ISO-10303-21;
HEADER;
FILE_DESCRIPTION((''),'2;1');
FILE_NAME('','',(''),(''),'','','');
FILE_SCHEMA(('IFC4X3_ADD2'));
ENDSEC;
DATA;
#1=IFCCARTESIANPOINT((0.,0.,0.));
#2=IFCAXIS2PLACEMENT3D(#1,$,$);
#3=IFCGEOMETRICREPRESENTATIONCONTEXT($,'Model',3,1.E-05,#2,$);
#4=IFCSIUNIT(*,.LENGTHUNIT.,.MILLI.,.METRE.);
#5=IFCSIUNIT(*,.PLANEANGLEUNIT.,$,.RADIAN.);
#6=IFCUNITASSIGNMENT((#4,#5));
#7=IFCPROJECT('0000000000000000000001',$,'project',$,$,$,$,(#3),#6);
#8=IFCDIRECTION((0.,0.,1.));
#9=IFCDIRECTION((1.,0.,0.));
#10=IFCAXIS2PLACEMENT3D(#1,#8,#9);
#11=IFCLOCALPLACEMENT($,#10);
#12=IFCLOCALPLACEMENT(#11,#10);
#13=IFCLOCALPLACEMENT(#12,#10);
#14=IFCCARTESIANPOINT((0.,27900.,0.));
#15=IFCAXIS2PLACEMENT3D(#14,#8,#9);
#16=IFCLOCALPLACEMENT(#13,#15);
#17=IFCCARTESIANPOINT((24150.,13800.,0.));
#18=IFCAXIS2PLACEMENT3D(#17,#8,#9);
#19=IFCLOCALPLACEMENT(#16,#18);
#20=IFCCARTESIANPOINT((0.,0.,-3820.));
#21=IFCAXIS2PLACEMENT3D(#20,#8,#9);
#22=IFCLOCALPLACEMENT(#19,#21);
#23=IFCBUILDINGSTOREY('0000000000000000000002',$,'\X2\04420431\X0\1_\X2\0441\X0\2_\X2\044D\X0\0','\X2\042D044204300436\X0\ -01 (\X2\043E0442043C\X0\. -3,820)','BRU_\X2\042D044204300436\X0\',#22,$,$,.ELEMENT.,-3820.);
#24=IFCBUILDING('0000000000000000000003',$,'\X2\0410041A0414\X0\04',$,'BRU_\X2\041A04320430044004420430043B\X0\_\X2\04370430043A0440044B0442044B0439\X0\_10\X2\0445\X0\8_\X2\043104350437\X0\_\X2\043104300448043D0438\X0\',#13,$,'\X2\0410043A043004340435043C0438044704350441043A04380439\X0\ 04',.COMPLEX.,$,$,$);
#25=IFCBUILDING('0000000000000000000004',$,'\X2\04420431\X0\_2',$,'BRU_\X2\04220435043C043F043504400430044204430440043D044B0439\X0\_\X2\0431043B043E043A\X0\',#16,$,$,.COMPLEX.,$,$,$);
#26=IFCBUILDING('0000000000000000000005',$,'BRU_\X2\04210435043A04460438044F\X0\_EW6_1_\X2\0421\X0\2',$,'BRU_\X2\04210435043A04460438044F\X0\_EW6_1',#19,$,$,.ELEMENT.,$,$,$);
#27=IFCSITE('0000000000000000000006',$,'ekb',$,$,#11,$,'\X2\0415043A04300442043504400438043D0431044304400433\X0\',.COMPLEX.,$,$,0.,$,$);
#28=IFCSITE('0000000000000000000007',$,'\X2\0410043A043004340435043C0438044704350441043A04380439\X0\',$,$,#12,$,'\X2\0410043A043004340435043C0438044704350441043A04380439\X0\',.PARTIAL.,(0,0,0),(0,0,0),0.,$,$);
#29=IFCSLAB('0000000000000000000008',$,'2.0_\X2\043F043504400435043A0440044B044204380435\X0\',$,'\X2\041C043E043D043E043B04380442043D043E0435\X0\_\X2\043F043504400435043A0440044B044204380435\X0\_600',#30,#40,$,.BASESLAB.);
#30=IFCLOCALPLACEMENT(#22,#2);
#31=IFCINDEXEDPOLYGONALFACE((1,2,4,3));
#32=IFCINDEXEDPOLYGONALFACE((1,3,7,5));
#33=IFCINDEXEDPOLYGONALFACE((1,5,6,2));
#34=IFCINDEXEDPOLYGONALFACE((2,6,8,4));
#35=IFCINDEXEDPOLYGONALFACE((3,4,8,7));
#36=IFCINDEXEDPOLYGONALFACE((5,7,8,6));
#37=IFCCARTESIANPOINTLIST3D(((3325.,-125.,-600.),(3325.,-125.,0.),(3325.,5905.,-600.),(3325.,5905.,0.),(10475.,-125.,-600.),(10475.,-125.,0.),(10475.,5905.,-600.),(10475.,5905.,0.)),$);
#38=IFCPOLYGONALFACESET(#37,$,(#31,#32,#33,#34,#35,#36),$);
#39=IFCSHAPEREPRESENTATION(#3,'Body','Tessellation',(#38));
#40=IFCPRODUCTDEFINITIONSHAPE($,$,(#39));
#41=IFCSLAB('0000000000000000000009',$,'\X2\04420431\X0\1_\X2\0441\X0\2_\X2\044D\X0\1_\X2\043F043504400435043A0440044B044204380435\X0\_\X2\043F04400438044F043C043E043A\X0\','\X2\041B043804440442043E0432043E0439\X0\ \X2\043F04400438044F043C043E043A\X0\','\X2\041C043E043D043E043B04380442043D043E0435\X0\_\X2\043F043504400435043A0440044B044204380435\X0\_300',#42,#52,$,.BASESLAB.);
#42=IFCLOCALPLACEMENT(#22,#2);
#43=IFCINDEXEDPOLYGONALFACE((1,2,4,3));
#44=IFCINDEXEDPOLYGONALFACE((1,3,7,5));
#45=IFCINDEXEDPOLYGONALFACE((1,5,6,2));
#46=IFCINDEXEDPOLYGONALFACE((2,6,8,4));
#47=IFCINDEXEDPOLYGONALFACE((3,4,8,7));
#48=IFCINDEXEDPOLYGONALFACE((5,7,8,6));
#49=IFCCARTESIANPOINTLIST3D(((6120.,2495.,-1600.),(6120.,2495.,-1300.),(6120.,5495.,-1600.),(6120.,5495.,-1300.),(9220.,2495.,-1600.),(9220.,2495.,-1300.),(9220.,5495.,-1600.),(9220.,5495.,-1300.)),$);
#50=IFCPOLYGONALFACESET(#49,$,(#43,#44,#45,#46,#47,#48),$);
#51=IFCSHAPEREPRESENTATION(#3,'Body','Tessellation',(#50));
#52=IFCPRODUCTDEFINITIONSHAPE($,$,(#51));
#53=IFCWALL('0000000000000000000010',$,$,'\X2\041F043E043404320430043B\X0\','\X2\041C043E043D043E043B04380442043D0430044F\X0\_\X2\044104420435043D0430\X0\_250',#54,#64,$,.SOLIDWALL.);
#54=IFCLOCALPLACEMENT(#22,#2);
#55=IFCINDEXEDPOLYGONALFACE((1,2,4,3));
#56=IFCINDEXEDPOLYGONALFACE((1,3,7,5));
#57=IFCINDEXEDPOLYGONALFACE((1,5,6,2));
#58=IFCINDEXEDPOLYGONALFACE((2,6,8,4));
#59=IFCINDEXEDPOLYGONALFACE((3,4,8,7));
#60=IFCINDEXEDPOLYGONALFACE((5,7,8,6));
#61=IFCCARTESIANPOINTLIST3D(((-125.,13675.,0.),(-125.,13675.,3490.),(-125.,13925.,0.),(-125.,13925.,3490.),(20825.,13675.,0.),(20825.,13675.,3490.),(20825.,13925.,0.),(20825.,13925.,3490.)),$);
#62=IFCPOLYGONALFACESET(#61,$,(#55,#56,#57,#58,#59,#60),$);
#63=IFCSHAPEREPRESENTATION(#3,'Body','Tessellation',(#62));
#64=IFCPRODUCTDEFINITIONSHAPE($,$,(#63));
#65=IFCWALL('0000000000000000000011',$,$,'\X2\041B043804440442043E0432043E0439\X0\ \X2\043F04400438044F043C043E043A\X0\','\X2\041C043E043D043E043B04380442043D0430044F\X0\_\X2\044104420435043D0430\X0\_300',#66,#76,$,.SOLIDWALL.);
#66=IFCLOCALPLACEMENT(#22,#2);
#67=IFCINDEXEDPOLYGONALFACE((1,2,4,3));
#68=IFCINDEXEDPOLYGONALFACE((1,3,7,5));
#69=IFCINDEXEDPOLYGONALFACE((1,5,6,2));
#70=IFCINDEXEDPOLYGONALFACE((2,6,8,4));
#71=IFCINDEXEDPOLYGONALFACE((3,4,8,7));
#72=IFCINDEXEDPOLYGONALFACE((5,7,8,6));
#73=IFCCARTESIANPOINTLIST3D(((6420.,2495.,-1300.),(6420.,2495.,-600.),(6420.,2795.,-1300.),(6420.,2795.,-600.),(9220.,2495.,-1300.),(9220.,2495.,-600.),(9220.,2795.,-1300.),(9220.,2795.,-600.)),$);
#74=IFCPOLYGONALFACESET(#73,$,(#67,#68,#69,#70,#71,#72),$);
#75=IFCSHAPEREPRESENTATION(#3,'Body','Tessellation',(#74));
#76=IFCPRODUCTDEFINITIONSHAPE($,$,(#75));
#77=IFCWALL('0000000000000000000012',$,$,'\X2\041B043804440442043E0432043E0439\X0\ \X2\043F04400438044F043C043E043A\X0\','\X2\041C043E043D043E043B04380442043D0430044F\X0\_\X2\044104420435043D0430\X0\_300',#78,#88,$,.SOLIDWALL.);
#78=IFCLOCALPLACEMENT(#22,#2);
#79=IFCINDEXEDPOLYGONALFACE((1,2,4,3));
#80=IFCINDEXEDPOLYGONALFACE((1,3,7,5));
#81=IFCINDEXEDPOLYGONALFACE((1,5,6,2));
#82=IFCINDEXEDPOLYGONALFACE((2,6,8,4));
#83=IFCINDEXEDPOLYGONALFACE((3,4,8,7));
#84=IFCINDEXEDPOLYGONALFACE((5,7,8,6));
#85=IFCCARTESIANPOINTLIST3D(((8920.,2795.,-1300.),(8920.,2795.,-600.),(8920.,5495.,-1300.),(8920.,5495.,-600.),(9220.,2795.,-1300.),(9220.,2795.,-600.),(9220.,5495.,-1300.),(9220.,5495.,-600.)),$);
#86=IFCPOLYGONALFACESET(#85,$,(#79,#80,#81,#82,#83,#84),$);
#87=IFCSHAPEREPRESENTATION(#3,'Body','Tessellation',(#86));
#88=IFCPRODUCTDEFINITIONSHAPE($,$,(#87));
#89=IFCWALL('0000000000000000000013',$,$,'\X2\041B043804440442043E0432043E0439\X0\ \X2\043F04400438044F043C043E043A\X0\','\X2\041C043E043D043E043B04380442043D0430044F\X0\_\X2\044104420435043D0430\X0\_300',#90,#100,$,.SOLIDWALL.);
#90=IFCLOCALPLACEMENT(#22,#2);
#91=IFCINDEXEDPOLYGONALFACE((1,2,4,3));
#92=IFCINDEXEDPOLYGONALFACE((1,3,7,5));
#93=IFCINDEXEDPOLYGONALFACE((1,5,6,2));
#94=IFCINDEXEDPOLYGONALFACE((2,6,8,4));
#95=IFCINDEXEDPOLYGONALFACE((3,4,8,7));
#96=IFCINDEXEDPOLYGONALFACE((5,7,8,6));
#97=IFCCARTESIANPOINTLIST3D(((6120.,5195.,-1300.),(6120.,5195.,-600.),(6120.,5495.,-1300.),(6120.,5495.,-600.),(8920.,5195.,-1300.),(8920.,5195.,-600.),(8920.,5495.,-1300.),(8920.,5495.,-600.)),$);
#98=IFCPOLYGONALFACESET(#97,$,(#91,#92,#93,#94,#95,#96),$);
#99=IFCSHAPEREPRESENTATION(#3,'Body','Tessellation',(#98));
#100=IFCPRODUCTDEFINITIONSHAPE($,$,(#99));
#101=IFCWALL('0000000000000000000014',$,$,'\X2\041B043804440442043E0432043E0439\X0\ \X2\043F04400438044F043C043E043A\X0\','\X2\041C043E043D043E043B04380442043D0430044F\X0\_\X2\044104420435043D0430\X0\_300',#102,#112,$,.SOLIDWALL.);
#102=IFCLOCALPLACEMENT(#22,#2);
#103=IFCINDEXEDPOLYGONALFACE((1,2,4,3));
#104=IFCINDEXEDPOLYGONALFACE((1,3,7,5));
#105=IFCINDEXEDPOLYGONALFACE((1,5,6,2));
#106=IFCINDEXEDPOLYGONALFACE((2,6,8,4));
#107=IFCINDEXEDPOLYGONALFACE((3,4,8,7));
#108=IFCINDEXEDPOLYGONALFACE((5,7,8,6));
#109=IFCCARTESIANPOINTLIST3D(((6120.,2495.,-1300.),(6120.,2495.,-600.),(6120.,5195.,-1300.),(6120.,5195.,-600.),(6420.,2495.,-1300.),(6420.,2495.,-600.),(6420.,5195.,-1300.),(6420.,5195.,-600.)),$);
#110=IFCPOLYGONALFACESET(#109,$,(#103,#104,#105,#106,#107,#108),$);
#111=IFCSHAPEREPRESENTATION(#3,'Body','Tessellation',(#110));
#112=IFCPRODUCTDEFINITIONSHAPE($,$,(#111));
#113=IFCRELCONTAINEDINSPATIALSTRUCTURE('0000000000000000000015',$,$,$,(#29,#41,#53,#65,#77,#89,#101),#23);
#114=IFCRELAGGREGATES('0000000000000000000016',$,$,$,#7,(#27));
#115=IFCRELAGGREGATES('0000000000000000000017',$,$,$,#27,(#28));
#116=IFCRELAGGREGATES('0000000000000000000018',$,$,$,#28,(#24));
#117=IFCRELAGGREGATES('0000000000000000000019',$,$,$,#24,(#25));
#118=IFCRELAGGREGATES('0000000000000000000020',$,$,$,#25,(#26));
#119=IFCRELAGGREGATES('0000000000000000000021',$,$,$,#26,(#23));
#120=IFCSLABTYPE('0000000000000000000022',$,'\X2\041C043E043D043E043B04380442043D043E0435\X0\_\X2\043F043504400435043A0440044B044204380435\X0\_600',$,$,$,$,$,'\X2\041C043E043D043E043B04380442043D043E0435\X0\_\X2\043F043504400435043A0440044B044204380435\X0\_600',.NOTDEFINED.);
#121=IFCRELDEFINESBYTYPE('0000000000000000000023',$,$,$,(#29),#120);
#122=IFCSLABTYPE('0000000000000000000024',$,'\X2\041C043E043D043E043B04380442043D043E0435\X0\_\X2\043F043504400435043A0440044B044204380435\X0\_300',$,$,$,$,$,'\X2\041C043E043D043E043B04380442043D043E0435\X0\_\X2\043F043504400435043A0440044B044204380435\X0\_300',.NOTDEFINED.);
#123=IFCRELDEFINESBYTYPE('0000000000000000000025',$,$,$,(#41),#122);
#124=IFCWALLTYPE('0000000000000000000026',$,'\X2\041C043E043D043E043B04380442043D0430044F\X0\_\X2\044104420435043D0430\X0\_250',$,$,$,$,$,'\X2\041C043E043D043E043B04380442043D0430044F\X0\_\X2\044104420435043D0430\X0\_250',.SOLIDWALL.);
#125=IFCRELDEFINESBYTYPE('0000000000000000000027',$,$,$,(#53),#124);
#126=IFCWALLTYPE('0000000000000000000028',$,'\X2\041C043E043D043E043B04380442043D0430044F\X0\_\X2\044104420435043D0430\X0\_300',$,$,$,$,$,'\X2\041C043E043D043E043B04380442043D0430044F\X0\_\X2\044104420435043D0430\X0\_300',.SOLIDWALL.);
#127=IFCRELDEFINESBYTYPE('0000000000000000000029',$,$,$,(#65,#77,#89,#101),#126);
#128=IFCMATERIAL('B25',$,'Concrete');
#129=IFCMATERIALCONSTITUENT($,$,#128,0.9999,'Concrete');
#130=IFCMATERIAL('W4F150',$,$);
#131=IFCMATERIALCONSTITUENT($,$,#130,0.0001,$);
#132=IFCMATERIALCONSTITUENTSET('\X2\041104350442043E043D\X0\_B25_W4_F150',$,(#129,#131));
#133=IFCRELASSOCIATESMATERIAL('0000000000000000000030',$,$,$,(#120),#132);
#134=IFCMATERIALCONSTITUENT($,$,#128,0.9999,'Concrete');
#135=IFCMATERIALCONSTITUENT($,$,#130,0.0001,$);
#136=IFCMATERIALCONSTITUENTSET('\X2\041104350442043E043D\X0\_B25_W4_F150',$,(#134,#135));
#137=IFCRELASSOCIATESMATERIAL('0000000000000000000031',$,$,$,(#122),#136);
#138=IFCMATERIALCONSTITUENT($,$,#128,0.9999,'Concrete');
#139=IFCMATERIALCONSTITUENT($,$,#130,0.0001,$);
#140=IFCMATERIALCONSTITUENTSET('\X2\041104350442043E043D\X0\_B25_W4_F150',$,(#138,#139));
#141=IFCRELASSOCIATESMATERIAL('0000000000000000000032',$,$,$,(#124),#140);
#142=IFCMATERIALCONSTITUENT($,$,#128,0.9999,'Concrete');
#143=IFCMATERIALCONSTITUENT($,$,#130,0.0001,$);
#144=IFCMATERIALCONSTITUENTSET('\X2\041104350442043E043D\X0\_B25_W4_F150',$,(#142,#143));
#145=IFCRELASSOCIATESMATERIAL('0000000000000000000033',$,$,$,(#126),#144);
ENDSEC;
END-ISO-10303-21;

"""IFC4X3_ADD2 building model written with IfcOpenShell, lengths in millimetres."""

from ifc_helpers import new_model, si_unit, frame, origin, origin_with_axes, origin_2d_with_axis, place, context, project, spatial, polyline, rectangle, outline, extrude, material, constituent, constituent_set, type_object, element, save


model = new_model("IFC4X3_ADD2")

# Units and contexts
model_context = context("Model", 3, precision=1e-05, world=origin())
ifc_project = project(units=[si_unit("LENGTHUNIT", "METRE", prefix="MILLI"), si_unit("PLANEANGLEUNIT", "RADIAN")], contexts=[model_context])

# Sites, buildings, storey
site_1_placement = place(None, origin_with_axes())
site_1 = spatial("IfcSite", under=ifc_project, at=site_1_placement, Name="ekb", LongName="Екатеринбург", CompositionType="COMPLEX", RefElevation=0.0)
site_2_placement = place(site_1_placement, origin_with_axes())
site_2 = spatial("IfcSite", under=site_1, at=site_2_placement, Name="Академический", LongName="Академический", CompositionType="PARTIAL", RefLatitude=(0, 0, 0), RefLongitude=(0, 0, 0), RefElevation=0.0)
building_1_placement = place(site_2_placement, origin_with_axes())
building_1 = spatial("IfcBuilding", under=site_2, at=building_1_placement, Name="АКД04", ObjectType="BRU_Квартал_закрытый_10х8_без_башни", LongName="Академический 04", CompositionType="COMPLEX")
building_2_placement = place(building_1_placement, frame((0.0, 27900.0, 0.0), z_axis=(0.0, 0.0, 1.0), x_axis=(1.0, 0.0, 0.0)))
building_2 = spatial("IfcBuilding", under=building_1, at=building_2_placement, Name="тб_2", ObjectType="BRU_Температурный_блок", CompositionType="COMPLEX")
building_3_placement = place(building_2_placement, frame((24150.0, 13800.0, 0.0), z_axis=(0.0, 0.0, 1.0), x_axis=(1.0, 0.0, 0.0)))
building_3 = spatial("IfcBuilding", under=building_2, at=building_3_placement, Name="BRU_Секция_EW6_1_С2", ObjectType="BRU_Секция_EW6_1", CompositionType="ELEMENT")
storey_placement = place(building_3_placement, frame((0.0, 0.0, -3820.0), z_axis=(0.0, 0.0, 1.0), x_axis=(1.0, 0.0, 0.0)))
storey = spatial("IfcBuildingStorey", under=building_3, at=storey_placement, Name="тб1_с2_э0", Description="Этаж -01 (отм. -3,820)", ObjectType="BRU_Этаж", CompositionType="ELEMENT", Elevation=-3820.0)

# Shared definitions
ifc_material_1 = material(Name="B25", Category="Concrete")
ifc_material_2 = material(Name="W4F150")

# Slabs
ifc_constituent_1 = constituent(ifc_material_1, Category="Concrete", fraction=0.9999)
ifc_constituent_2 = constituent(ifc_material_2, fraction=0.0001)
ifc_constituent_set_1 = constituent_set(constituents=[ifc_constituent_1, ifc_constituent_2], Name="Бетон_B25_W4_F150")
slab_type_1 = type_object("IfcSlabType", Name="Монолитное_перекрытие_600", ElementType="Монолитное_перекрытие_600", PredefinedType="NOTDEFINED", material=ifc_constituent_set_1)
slab_1_placement = place(storey_placement, frame((0.0, 0.0, -600.0), z_axis=(0.0, 0.0, 1.0), x_axis=(1.0, 0.0, 0.0)))
element("IfcSlab", 1, at=slab_1_placement, inside=storey, type_object=slab_type_1, Name="2.0_перекрытие", ObjectType="Монолитное_перекрытие_600", PredefinedType="BASESLAB", context=model_context, shape_type="SweptSolid", body=[
    extrude(outline(polyline([(3325.0, -125.0), (10475.0, -125.0), (10475.0, 5905.0), (3325.0, 5905.0), (3325.0, -125.0)])), origin_with_axes(), (0.0, 0.0, 1.0), 600.0),
])
ifc_constituent_3 = constituent(ifc_material_1, Category="Concrete", fraction=0.9999)
ifc_constituent_4 = constituent(ifc_material_2, fraction=0.0001)
ifc_constituent_set_2 = constituent_set(constituents=[ifc_constituent_3, ifc_constituent_4], Name="Бетон_B25_W4_F150")
slab_type_2 = type_object("IfcSlabType", Name="Монолитное_перекрытие_300", ElementType="Монолитное_перекрытие_300", PredefinedType="NOTDEFINED", material=ifc_constituent_set_2)
slab_2_placement = place(storey_placement, frame((7670.0, 3995.0, -1600.0), z_axis=(0.0, 0.0, 1.0), x_axis=(1.0, 0.0, 0.0)))
element("IfcSlab", 2, at=slab_2_placement, inside=storey, type_object=slab_type_2, Name="тб1_с2_э1_перекрытие_приямок", Description="Лифтовой приямок", ObjectType="Монолитное_перекрытие_300", PredefinedType="BASESLAB", context=model_context, shape_type="SweptSolid", body=[
    extrude(outline(polyline([(-1550.0, -1500.0), (-1550.0, 1500.0), (1550.0, 1500.0), (1550.0, -1500.0), (-1550.0, -1500.0)])), origin_with_axes(), (0.0, 0.0, 1.0), 300.0),
])

# Walls
ifc_constituent_5 = constituent(ifc_material_1, Category="Concrete", fraction=0.9999)
ifc_constituent_6 = constituent(ifc_material_2, fraction=0.0001)
ifc_constituent_set_3 = constituent_set(constituents=[ifc_constituent_5, ifc_constituent_6], Name="Бетон_B25_W4_F150")
wall_type_1 = type_object("IfcWallType", Name="Монолитная_стена_250", ElementType="Монолитная_стена_250", PredefinedType="SOLIDWALL", material=ifc_constituent_set_3)
wall_1_placement = place(storey_placement, frame((-125.0, 13800.0, 0.0), z_axis=(0.0, 0.0, 1.0), x_axis=(1.0, 0.0, 0.0)))
element("IfcWall", 3, at=wall_1_placement, inside=storey, type_object=wall_type_1, Description="Подвал", ObjectType="Монолитная_стена_250", PredefinedType="SOLIDWALL", context=model_context, shape_type="SweptSolid", body=[
    extrude(rectangle(XDim=20950.0, YDim=250.0, at=origin_2d_with_axis()), frame((10475.0, 0.0, 0.0), z_axis=(0.0, 0.0, 1.0), x_axis=(1.0, 0.0, 0.0)), (0.0, 0.0, 1.0), 3490.0),
])
ifc_constituent_7 = constituent(ifc_material_1, Category="Concrete", fraction=0.9999)
ifc_constituent_8 = constituent(ifc_material_2, fraction=0.0001)
ifc_constituent_set_4 = constituent_set(constituents=[ifc_constituent_7, ifc_constituent_8], Name="Бетон_B25_W4_F150")
wall_type_2 = type_object("IfcWallType", Name="Монолитная_стена_300", ElementType="Монолитная_стена_300", PredefinedType="SOLIDWALL", material=ifc_constituent_set_4)
wall_2_placement = place(storey_placement, frame((6420.0, 2645.0, -1300.0), z_axis=(0.0, 0.0, 1.0), x_axis=(1.0, 0.0, 0.0)))
element("IfcWall", 4, at=wall_2_placement, inside=storey, type_object=wall_type_2, Description="Лифтовой приямок", ObjectType="Монолитная_стена_300", PredefinedType="SOLIDWALL", context=model_context, shape_type="SweptSolid", body=[
    extrude(rectangle(XDim=2800.0, YDim=300.0, at=origin_2d_with_axis()), frame((1400.0, 0.0, 0.0), z_axis=(0.0, 0.0, 1.0), x_axis=(1.0, 0.0, 0.0)), (0.0, 0.0, 1.0), 700.0),
])
wall_3_placement = place(storey_placement, frame((9070.0, 2795.0, -1300.0), z_axis=(0.0, 0.0, 1.0), x_axis=(0.0, 1.0, 0.0)))
element("IfcWall", 5, at=wall_3_placement, inside=storey, type_object=wall_type_2, Description="Лифтовой приямок", ObjectType="Монолитная_стена_300", PredefinedType="SOLIDWALL", context=model_context, shape_type="SweptSolid", body=[
    extrude(rectangle(XDim=2700.0, YDim=300.0, at=origin_2d_with_axis()), frame((1350.0, 0.0, 0.0), z_axis=(0.0, 0.0, 1.0), x_axis=(1.0, 0.0, 0.0)), (0.0, 0.0, 1.0), 700.0),
])
wall_4_placement = place(storey_placement, frame((8920.0, 5345.0, -1300.0), z_axis=(0.0, 0.0, 1.0), x_axis=(-1.0, 0.0, 0.0)))
element("IfcWall", 6, at=wall_4_placement, inside=storey, type_object=wall_type_2, Description="Лифтовой приямок", ObjectType="Монолитная_стена_300", PredefinedType="SOLIDWALL", context=model_context, shape_type="SweptSolid", body=[
    extrude(rectangle(XDim=2800.0, YDim=300.0, at=origin_2d_with_axis()), frame((1400.0, 0.0, 0.0), z_axis=(0.0, 0.0, 1.0), x_axis=(1.0, 0.0, 0.0)), (0.0, 0.0, 1.0), 700.0),
])
wall_5_placement = place(storey_placement, frame((6270.0, 5195.0, -1300.0), z_axis=(0.0, 0.0, 1.0), x_axis=(0.0, -1.0, 0.0)))
element("IfcWall", 7, at=wall_5_placement, inside=storey, type_object=wall_type_2, Description="Лифтовой приямок", ObjectType="Монолитная_стена_300", PredefinedType="SOLIDWALL", context=model_context, shape_type="SweptSolid", body=[
    extrude(rectangle(XDim=2700.0, YDim=300.0, at=origin_2d_with_axis()), frame((1350.0, 0.0, 0.0), z_axis=(0.0, 0.0, 1.0), x_axis=(1.0, 0.0, 0.0)), (0.0, 0.0, 1.0), 700.0),
])

save(model, "model.ifc")
